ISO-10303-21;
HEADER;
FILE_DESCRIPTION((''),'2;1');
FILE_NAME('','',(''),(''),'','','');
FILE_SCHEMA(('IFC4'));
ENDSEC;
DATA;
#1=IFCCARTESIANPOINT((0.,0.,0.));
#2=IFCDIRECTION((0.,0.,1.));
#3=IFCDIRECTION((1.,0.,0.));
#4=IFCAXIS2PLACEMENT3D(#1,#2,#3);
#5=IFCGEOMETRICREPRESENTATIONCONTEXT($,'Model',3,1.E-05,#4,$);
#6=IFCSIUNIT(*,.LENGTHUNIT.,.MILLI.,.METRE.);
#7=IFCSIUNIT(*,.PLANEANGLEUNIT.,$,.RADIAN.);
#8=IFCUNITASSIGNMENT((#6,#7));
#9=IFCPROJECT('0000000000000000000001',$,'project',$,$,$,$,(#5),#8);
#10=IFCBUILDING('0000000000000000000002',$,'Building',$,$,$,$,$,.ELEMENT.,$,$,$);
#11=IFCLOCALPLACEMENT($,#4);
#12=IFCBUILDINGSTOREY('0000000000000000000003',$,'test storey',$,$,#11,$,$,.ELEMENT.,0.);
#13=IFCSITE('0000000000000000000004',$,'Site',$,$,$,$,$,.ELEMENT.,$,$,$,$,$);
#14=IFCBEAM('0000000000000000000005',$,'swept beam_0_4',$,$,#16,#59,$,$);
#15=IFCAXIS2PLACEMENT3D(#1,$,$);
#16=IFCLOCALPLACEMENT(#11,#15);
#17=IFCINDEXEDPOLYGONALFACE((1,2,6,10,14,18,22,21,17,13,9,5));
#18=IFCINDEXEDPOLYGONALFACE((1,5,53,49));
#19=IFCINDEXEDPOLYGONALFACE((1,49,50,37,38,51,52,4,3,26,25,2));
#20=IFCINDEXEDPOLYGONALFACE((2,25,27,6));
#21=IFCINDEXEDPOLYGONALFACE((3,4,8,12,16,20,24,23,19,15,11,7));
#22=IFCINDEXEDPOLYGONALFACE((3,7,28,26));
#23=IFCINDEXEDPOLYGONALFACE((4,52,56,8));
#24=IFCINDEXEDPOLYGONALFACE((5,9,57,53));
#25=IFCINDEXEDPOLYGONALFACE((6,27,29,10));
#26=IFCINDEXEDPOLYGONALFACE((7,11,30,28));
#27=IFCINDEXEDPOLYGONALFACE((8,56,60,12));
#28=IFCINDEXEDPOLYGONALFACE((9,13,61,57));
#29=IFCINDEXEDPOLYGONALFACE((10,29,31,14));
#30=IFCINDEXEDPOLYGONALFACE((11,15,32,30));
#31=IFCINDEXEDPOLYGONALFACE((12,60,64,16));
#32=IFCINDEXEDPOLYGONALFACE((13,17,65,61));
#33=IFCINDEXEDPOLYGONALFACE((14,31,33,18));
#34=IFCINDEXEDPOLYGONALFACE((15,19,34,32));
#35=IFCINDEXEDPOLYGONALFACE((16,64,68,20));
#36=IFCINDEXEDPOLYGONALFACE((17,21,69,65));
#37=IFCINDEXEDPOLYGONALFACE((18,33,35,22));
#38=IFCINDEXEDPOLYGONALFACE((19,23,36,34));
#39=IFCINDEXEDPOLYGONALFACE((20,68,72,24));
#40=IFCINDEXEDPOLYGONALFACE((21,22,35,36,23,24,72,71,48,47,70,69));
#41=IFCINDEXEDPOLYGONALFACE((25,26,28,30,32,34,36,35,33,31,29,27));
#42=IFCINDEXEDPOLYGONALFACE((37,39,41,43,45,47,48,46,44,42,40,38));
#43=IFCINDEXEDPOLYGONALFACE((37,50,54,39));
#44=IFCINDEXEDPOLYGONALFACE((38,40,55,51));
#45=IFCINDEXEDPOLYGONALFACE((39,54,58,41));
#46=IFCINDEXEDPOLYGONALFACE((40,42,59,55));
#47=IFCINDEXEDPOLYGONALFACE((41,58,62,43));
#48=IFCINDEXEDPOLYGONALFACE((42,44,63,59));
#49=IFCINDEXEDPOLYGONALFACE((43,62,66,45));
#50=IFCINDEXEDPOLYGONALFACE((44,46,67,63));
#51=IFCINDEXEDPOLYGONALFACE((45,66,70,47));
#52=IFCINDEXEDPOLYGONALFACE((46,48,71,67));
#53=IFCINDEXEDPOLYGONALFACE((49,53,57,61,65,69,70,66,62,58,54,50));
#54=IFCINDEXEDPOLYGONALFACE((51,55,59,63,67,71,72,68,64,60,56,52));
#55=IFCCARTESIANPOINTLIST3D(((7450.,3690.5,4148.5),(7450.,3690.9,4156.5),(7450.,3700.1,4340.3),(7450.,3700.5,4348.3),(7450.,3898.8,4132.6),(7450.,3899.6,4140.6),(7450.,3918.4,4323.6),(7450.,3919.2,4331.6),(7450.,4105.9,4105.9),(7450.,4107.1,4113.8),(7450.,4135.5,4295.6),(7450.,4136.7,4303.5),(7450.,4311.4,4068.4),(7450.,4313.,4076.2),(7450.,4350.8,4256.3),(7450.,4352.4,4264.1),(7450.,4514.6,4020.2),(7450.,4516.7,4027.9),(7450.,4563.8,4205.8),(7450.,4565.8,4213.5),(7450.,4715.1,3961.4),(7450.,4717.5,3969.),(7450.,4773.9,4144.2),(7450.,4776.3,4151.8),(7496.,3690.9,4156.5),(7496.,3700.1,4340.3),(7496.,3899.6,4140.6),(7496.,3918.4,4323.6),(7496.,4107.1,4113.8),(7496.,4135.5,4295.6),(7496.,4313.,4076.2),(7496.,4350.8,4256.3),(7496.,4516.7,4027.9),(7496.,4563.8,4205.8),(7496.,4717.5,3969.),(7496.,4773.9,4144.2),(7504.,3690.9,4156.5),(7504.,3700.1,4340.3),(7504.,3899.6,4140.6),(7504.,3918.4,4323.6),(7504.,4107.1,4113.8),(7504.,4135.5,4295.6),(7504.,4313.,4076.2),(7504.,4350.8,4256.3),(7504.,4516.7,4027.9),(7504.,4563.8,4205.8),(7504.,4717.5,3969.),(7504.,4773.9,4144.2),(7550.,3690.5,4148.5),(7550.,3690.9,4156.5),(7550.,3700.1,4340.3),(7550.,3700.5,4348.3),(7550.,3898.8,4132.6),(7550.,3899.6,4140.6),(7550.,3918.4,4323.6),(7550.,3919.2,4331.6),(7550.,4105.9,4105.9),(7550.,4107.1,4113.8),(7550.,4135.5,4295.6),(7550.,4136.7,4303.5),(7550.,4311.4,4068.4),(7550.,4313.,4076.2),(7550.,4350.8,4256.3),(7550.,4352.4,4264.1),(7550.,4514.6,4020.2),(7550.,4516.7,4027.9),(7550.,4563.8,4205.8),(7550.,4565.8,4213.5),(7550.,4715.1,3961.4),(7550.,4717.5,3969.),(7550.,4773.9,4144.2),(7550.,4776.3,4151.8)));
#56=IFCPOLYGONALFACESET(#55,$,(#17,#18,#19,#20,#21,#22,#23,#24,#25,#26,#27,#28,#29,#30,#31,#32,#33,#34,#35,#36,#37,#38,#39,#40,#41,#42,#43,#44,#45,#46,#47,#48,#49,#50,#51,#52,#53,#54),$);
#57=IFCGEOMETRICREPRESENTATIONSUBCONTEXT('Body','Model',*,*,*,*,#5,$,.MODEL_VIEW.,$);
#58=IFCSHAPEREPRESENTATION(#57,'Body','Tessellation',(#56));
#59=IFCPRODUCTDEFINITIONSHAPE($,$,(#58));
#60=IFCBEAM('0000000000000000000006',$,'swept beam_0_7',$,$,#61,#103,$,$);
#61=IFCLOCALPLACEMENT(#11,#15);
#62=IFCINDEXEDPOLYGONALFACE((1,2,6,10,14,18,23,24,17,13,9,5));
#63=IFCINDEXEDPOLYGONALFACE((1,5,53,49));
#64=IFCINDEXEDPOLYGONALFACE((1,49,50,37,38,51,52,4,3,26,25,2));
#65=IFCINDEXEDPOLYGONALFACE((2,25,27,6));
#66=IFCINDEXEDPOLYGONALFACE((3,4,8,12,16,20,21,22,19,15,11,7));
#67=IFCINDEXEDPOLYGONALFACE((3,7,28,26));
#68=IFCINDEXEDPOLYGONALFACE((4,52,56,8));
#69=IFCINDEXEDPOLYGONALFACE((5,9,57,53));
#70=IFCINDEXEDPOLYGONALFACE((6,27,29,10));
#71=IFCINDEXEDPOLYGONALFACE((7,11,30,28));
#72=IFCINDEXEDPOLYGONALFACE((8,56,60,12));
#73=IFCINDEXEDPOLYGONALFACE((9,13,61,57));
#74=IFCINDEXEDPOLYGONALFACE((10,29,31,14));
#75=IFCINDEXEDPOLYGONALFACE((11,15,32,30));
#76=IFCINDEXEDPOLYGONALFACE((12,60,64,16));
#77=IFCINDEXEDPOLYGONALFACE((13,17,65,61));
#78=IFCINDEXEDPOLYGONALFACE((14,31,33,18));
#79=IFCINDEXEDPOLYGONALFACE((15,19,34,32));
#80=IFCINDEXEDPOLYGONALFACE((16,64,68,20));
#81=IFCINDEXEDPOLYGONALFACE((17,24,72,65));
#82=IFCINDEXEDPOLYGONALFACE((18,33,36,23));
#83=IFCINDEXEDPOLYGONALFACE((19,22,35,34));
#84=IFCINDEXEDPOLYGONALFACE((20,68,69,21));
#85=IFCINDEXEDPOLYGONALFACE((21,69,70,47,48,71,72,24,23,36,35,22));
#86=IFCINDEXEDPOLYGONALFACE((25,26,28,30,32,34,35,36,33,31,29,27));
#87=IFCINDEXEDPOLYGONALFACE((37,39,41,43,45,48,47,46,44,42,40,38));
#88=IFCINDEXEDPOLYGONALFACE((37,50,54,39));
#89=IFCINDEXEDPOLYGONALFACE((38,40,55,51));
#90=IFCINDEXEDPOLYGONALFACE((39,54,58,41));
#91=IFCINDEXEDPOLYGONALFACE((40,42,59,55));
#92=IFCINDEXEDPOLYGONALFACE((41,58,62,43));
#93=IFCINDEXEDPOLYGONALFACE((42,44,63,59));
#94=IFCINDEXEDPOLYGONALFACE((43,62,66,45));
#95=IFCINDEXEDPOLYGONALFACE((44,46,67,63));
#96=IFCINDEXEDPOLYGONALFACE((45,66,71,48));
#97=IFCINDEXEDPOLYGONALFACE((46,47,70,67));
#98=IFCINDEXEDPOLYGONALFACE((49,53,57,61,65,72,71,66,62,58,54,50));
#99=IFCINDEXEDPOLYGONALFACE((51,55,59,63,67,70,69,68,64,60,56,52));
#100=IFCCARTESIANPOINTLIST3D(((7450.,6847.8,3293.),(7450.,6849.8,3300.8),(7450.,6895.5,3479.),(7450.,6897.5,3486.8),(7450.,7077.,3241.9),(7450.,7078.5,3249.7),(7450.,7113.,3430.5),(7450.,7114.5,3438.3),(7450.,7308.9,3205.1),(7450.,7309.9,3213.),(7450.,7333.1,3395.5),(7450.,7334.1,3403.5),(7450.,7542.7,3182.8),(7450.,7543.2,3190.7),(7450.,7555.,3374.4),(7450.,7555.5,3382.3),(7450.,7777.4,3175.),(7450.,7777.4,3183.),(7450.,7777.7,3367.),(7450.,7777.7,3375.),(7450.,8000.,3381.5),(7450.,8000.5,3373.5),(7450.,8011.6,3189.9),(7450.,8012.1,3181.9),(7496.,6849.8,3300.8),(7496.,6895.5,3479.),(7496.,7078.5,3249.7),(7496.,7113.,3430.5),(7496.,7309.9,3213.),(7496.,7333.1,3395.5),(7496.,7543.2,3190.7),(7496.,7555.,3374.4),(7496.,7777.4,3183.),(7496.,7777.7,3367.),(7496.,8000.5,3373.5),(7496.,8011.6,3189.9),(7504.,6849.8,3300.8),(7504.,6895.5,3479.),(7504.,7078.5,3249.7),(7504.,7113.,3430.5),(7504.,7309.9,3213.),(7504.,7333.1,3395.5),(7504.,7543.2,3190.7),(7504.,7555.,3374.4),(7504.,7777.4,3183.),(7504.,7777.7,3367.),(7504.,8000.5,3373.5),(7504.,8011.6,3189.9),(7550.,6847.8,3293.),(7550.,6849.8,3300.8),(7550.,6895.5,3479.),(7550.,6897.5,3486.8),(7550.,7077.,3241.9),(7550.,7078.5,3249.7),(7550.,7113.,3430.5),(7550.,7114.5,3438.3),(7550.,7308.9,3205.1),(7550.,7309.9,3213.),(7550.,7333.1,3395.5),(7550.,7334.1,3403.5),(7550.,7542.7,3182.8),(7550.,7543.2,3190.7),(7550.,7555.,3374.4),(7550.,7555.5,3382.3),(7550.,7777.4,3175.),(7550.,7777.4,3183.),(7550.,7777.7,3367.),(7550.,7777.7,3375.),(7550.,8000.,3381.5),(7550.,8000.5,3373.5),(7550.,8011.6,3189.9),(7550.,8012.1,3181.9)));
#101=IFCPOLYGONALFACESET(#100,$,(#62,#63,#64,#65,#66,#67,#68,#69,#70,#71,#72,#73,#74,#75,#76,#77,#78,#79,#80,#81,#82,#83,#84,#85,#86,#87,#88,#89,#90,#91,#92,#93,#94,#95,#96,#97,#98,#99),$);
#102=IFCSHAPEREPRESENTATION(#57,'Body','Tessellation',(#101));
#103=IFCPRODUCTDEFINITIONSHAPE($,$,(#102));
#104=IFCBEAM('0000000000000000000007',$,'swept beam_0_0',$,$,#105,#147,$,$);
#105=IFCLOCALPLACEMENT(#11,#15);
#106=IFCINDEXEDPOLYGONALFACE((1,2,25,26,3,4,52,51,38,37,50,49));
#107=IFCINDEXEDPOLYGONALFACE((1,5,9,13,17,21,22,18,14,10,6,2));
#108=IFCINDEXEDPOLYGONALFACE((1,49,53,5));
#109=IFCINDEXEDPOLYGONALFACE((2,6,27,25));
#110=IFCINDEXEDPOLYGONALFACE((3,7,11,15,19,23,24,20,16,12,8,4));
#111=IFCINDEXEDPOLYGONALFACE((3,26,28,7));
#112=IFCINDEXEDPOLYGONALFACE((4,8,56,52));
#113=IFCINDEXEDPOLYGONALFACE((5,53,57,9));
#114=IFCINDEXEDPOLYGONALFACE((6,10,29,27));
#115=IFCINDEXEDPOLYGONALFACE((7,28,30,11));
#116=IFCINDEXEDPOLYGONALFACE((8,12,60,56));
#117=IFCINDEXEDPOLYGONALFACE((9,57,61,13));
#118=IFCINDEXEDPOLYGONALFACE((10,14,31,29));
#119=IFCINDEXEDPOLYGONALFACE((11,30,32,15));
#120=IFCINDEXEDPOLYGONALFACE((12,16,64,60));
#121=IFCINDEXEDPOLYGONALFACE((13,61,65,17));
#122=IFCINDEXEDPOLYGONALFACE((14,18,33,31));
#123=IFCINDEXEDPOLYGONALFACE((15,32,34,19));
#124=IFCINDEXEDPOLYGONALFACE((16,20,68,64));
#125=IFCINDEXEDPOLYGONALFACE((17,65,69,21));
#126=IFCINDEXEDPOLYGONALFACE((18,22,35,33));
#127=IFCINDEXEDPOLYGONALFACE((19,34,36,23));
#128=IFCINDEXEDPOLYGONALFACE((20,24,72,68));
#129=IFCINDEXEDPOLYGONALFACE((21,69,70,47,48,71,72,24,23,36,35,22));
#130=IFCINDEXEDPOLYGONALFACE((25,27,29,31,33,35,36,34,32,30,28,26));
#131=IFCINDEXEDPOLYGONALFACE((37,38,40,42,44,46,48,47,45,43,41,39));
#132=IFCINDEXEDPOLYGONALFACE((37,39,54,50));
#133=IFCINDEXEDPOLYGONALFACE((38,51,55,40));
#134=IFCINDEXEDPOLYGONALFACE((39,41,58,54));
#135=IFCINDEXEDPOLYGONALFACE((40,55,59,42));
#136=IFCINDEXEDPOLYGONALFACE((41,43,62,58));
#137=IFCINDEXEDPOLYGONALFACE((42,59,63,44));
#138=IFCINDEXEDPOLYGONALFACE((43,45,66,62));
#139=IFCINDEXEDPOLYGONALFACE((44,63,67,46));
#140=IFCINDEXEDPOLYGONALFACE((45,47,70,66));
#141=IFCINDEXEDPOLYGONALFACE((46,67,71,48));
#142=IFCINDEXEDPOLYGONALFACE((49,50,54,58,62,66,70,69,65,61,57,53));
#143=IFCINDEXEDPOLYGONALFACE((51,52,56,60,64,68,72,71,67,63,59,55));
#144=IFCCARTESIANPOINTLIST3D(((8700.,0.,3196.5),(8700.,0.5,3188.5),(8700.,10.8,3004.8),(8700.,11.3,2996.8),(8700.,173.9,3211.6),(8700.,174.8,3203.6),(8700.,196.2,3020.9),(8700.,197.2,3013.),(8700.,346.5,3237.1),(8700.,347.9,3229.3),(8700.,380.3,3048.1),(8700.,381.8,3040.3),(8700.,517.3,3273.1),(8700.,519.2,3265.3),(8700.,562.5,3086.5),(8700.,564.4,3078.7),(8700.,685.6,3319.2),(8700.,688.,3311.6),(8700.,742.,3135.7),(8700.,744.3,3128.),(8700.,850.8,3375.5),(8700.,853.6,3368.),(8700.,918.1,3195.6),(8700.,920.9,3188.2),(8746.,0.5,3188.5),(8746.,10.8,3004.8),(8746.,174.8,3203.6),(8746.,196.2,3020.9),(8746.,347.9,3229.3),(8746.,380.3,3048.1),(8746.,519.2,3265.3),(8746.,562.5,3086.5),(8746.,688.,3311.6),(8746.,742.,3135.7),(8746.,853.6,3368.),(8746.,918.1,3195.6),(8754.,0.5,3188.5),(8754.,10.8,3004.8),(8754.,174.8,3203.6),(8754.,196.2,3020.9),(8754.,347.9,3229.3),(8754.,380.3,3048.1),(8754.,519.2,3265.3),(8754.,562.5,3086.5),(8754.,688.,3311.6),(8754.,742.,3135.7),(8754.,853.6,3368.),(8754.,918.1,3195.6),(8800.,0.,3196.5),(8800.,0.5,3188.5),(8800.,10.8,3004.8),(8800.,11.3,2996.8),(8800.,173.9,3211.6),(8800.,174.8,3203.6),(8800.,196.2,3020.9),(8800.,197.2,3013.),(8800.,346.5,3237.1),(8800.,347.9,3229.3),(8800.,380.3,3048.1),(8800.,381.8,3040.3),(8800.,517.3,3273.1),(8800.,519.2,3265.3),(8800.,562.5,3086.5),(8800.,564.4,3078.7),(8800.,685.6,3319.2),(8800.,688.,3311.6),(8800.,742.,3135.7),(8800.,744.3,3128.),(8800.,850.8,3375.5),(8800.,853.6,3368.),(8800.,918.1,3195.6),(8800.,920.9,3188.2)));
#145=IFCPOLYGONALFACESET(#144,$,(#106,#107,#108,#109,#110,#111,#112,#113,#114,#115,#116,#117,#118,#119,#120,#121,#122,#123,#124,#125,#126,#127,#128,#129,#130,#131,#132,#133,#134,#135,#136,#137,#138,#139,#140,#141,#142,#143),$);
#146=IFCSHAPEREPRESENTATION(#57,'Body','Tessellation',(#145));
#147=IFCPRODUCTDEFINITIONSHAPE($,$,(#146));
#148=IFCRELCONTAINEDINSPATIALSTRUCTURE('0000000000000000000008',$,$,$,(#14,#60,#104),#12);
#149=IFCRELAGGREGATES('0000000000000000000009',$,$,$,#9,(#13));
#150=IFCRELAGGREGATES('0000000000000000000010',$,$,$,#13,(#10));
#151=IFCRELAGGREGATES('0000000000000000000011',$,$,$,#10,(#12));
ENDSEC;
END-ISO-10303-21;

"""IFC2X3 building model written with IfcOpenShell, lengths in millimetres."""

from ifc_helpers import new_model, entity, si_unit, origin_with_axes, place, context, subcontext, project, spatial, element, save


model = new_model("IFC2X3")

# Units and contexts
model_context = context("Model", 3, precision=1e-05, world=origin_with_axes())
body_context = subcontext(model_context, "Body", "Model", "MODEL_VIEW")
ifc_project = project(units=[si_unit("LENGTHUNIT", "METRE", prefix="MILLI"), si_unit("PLANEANGLEUNIT", "RADIAN")], contexts=[model_context])

# Site, building, storey
site = spatial("IfcSite", under=ifc_project, Name="Site", CompositionType="ELEMENT")
building = spatial("IfcBuilding", under=site, Name="Building", CompositionType="ELEMENT")
storey_placement = place(None, origin_with_axes())
storey = spatial("IfcBuildingStorey", under=building, at=storey_placement, Name="test storey", CompositionType="ELEMENT", Elevation=0.0)

# Beams
beam_1_placement = place(storey_placement, origin_with_axes())
element("IfcBeam", 1, at=beam_1_placement, inside=storey, Name="swept beam_0_4", context=body_context, shape_type="SweptSolid", body=[
    entity("IfcRevolvedAreaSolid", entity("IfcArbitraryClosedProfileDef", "AREA", None, entity("IfcPolyline", [entity("IfcCartesianPoint", [-192.0, -50.0]), entity("IfcCartesianPoint", [-192.0, -4.0]), entity("IfcCartesianPoint", [-8.0, -4.0]), entity("IfcCartesianPoint", [-8.0, -50.0]), entity("IfcCartesianPoint", [0.0, -50.0]), entity("IfcCartesianPoint", [0.0, 50.0]), entity("IfcCartesianPoint", [-8.0, 50.0]), entity("IfcCartesianPoint", [-8.0, 4.0]), entity("IfcCartesianPoint", [-192.0, 4.0]), entity("IfcCartesianPoint", [-192.0, 50.0]), entity("IfcCartesianPoint", [-200.0, 50.0]), entity("IfcCartesianPoint", [-200.0, -50.0]), entity("IfcCartesianPoint", [-192.0, -50.0])])), entity("IfcAxis2Placement3D", entity("IfcCartesianPoint", [7500.0, 3700.5, 4348.3]), entity("IfcDirection", [0.0, -0.9988, 0.05]), entity("IfcDirection", [0.0, 0.05, 0.9988])), entity("IfcAxis1Placement", entity("IfcCartesianPoint", [-4198.8, 0.0, 0.0]), entity("IfcDirection", [0.0, 1.0, 0.0])), 0.261196),
])
beam_2_placement = place(storey_placement, origin_with_axes())
element("IfcBeam", 2, at=beam_2_placement, inside=storey, Name="swept beam_0_7", context=body_context, shape_type="SweptSolid", body=[
    entity("IfcRevolvedAreaSolid", entity("IfcArbitraryClosedProfileDef", "AREA", None, entity("IfcPolyline", [entity("IfcCartesianPoint", [192.0, 50.0]), entity("IfcCartesianPoint", [192.0, 4.0]), entity("IfcCartesianPoint", [8.0, 4.0]), entity("IfcCartesianPoint", [8.0, 50.0]), entity("IfcCartesianPoint", [0.0, 50.0]), entity("IfcCartesianPoint", [0.0, -50.0]), entity("IfcCartesianPoint", [8.0, -50.0]), entity("IfcCartesianPoint", [8.0, -4.0]), entity("IfcCartesianPoint", [192.0, -4.0]), entity("IfcCartesianPoint", [192.0, -50.0]), entity("IfcCartesianPoint", [200.0, -50.0]), entity("IfcCartesianPoint", [200.0, 50.0]), entity("IfcCartesianPoint", [192.0, 50.0])])), entity("IfcAxis2Placement3D", entity("IfcCartesianPoint", [7500.0, 6897.5, 3486.8]), entity("IfcDirection", [0.0, -0.9687, 0.2481]), entity("IfcDirection", [0.0, -0.2481, -0.9687])), entity("IfcAxis1Placement", entity("IfcCartesianPoint", [-3574.4, 0.0, 0.0]), entity("IfcDirection", [0.0, 1.0, 0.0])), 0.311106),
])
beam_3_placement = place(storey_placement, origin_with_axes())
element("IfcBeam", 3, at=beam_3_placement, inside=storey, Name="swept beam_0_0", context=body_context, shape_type="SweptSolid", body=[
    entity("IfcRevolvedAreaSolid", entity("IfcArbitraryClosedProfileDef", "AREA", None, entity("IfcPolyline", [entity("IfcCartesianPoint", [192.0, 50.0]), entity("IfcCartesianPoint", [192.0, 4.0]), entity("IfcCartesianPoint", [8.0, 4.0]), entity("IfcCartesianPoint", [8.0, 50.0]), entity("IfcCartesianPoint", [0.0, 50.0]), entity("IfcCartesianPoint", [0.0, -50.0]), entity("IfcCartesianPoint", [8.0, -50.0]), entity("IfcCartesianPoint", [8.0, -4.0]), entity("IfcCartesianPoint", [192.0, -4.0]), entity("IfcCartesianPoint", [192.0, -50.0]), entity("IfcCartesianPoint", [200.0, -50.0]), entity("IfcCartesianPoint", [200.0, 50.0]), entity("IfcCartesianPoint", [192.0, 50.0])])), entity("IfcAxis2Placement3D", entity("IfcCartesianPoint", [8750.0, 0.0, 3196.5]), entity("IfcDirection", [0.0, -0.9984, -0.0564]), entity("IfcDirection", [0.0, 0.0564, -0.9984])), entity("IfcAxis1Placement", entity("IfcCartesianPoint", [-2892.0, 0.0, 0.0]), entity("IfcDirection", [0.0, 1.0, 0.0])), 0.301785),
])

save(model, "model.ifc")
